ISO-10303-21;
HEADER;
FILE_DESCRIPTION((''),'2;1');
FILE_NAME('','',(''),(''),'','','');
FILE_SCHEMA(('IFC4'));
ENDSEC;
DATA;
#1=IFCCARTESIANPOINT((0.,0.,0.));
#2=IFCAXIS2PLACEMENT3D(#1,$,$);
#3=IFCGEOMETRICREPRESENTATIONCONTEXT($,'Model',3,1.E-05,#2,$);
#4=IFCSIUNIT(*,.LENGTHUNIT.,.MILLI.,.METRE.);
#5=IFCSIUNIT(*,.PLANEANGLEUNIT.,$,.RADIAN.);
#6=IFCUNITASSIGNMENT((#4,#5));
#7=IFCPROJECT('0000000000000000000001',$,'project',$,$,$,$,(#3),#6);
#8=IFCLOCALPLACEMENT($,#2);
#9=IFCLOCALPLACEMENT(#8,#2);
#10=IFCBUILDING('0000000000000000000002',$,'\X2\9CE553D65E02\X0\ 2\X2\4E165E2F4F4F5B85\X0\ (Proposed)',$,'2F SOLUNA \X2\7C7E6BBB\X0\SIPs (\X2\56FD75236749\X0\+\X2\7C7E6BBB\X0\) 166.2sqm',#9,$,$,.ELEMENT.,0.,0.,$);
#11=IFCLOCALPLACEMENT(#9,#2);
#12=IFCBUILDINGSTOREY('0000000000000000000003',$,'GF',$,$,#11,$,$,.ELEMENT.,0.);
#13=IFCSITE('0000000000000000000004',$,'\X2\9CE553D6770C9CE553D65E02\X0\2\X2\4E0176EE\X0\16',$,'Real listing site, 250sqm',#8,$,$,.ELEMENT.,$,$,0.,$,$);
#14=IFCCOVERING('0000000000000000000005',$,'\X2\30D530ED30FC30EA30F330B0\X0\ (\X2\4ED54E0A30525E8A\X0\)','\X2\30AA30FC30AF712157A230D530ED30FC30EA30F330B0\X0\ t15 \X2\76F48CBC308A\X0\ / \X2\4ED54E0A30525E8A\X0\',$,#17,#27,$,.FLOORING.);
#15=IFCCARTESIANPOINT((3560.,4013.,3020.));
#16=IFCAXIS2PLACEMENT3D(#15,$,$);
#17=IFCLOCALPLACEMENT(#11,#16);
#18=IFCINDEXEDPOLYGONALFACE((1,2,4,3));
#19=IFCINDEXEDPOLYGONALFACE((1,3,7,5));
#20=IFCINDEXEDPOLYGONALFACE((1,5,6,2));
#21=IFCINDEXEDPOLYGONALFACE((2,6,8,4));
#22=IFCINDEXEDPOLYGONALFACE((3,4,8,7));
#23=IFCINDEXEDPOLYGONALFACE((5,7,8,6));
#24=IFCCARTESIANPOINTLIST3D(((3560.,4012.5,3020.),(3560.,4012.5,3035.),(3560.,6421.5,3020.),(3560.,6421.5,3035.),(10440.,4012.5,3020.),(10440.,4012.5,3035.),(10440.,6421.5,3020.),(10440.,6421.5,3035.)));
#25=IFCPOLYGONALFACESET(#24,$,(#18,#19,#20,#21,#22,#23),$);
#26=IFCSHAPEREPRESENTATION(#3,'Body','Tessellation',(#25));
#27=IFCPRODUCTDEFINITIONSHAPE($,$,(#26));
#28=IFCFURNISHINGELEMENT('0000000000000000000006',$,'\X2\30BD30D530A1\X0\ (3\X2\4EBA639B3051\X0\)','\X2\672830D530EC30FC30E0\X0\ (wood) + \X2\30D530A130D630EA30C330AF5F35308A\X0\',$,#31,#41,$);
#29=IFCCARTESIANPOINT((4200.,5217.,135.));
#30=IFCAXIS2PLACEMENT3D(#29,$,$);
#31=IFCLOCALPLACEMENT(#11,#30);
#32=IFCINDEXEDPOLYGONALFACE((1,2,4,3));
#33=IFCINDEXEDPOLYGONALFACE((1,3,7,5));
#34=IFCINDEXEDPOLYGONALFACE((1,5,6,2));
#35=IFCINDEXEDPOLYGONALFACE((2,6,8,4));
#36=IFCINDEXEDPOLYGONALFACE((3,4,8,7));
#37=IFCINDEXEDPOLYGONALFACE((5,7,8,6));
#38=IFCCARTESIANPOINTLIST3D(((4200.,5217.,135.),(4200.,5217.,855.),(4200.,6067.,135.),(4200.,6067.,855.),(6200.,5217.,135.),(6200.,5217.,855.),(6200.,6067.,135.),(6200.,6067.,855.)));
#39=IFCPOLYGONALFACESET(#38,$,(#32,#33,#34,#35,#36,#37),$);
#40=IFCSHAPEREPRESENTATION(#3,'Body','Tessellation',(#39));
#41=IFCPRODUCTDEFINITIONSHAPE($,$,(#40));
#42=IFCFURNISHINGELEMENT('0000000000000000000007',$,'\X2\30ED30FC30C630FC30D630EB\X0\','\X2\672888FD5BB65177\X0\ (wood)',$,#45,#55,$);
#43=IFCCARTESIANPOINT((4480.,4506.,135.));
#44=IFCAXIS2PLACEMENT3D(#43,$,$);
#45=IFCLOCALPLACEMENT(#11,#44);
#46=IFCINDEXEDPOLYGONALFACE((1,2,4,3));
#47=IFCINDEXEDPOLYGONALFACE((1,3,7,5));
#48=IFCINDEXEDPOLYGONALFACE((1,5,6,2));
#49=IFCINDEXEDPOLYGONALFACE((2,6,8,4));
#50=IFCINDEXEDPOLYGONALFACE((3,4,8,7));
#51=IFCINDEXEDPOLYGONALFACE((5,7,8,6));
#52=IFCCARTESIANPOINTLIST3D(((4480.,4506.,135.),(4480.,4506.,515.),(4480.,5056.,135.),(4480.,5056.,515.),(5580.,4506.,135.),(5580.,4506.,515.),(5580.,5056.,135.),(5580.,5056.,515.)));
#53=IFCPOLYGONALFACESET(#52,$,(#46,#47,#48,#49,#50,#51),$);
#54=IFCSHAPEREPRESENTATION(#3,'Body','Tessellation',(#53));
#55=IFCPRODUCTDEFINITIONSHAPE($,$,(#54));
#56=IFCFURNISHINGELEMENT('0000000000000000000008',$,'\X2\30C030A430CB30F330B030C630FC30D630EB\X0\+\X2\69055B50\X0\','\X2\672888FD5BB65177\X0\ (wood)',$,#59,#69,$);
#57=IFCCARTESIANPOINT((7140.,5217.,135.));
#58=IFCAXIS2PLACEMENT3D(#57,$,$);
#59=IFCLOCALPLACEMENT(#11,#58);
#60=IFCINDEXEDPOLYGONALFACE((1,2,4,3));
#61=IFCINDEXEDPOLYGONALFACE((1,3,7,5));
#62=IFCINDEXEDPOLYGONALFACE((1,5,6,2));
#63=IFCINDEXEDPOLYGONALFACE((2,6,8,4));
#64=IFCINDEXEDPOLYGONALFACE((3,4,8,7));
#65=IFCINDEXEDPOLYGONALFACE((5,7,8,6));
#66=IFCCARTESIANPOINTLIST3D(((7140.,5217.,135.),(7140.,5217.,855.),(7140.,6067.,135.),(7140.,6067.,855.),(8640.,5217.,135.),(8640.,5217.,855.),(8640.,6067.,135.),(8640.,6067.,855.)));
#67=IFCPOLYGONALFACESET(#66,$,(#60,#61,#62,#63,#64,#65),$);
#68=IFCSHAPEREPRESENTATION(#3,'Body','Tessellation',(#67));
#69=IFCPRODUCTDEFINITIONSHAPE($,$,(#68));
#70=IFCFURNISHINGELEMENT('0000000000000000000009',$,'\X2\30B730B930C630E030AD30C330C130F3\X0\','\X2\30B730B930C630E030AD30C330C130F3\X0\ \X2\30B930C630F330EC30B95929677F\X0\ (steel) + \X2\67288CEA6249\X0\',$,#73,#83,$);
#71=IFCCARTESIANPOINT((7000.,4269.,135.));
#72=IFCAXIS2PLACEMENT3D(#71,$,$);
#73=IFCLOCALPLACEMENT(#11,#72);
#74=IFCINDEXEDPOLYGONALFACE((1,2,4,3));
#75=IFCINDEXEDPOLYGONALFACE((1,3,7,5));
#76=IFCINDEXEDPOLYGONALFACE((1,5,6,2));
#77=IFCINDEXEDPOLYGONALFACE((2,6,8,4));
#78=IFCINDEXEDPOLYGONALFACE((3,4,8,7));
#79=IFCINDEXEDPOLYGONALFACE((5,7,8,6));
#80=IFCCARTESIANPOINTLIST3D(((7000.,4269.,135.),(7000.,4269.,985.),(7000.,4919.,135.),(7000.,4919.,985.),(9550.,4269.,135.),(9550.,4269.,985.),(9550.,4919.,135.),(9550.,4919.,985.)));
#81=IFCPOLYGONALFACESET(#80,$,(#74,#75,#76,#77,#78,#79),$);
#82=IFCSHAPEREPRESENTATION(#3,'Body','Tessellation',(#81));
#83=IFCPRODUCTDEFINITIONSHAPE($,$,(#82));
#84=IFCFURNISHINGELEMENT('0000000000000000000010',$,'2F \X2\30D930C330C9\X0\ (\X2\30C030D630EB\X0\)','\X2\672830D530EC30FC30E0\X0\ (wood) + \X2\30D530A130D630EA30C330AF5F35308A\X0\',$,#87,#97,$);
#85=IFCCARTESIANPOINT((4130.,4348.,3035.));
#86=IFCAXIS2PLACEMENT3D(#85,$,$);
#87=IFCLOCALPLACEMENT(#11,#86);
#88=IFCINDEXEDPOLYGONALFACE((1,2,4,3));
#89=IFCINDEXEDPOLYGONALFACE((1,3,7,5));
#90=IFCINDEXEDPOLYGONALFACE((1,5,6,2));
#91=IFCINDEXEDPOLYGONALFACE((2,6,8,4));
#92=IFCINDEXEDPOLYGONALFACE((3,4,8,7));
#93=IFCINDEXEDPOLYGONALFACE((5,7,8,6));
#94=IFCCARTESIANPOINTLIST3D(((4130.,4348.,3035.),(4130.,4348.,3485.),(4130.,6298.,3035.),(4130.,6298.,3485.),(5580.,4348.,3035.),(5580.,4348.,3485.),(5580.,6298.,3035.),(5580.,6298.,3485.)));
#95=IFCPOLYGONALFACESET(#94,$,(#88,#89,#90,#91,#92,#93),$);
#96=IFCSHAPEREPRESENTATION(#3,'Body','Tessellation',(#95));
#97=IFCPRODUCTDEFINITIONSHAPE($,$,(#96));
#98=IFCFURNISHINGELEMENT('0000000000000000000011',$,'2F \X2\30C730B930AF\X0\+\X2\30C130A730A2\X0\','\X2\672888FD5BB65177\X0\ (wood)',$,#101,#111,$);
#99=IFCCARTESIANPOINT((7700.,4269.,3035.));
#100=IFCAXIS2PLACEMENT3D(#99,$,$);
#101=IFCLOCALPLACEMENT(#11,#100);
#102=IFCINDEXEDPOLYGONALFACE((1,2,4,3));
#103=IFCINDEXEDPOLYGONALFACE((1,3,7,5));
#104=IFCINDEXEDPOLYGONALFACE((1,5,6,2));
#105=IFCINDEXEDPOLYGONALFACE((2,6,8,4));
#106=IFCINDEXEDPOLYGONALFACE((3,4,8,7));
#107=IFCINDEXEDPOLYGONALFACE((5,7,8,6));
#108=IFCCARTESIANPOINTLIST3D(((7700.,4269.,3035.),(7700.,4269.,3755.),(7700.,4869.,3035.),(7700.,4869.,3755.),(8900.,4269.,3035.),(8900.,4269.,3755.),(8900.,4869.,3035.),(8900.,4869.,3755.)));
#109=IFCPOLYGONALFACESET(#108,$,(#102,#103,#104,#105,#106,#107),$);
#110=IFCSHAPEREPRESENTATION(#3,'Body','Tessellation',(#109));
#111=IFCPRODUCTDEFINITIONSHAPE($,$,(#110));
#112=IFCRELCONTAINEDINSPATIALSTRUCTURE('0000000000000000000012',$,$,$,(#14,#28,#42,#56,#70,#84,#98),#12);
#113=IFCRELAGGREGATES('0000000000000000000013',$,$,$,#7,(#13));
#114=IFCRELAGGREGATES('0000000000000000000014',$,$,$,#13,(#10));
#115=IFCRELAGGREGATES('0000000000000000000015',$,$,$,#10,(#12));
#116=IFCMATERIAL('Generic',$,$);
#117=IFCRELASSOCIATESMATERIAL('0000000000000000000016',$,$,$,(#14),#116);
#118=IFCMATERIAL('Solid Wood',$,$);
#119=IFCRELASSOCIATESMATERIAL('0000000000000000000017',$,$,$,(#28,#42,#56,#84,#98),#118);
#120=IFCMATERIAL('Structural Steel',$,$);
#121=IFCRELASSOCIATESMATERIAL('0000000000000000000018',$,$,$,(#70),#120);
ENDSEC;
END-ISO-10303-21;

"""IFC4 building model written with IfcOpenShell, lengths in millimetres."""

from ifc_helpers import new_model, si_unit, frame, frame_2d, origin, place, context, project, spatial, rectangle, extrude, material, element, save


model = new_model("IFC4")

# Units and contexts
model_context = context("Model", 3, precision=1e-05, world=origin())
ifc_project = project(units=[si_unit("LENGTHUNIT", "METRE", prefix="MILLI"), si_unit("PLANEANGLEUNIT", "RADIAN")], contexts=[model_context])

# Site, building, storey
site_placement = place(None, origin())
site = spatial("IfcSite", under=ifc_project, at=site_placement, Name="鳥取県鳥取市2丁目16", ObjectType="Real listing site, 250sqm", CompositionType="ELEMENT", RefElevation=0.0)
building_placement = place(site_placement, origin())
building = spatial("IfcBuilding", under=site, at=building_placement, Name="鳥取市 2世帯住宅 (Proposed)", ObjectType="2F SOLUNA 籾殻SIPs (国産杉+籾殻) 166.2sqm", CompositionType="ELEMENT", ElevationOfRefHeight=0.0, ElevationOfTerrain=0.0)
storey_placement = place(building_placement, origin())
storey = spatial("IfcBuildingStorey", under=building, at=storey_placement, Name="GF", CompositionType="ELEMENT", Elevation=0.0)

# Shared definitions
ifc_material_1 = material(Name="Solid Wood")

# Shared definitions
ifc_material_2 = material(Name="Generic")

# Shared definitions
ifc_material_3 = material(Name="Structural Steel")

# Covering
covering_placement = place(storey_placement, frame((3560.0, 4013.0, 3020.0)))
element("IfcCovering", 1, at=covering_placement, inside=storey, material=ifc_material_2, Name="フローリング (仕上げ床)", Description="オーク無垢フローリング t15 直貼り / 仕上げ床", PredefinedType="FLOORING", context=model_context, shape_type="SweptSolid", body=[
    extrude(rectangle(XDim=6880.0, YDim=2409.0, at=frame_2d((3440.0, 1204.0))), frame((3560.0, 4013.0, 3020.0)), (0.0, 0.0, 1.0), 15.0),
])

# Furnishing elements
furnishing_1_placement = place(storey_placement, frame((4200.0, 5217.0, 135.0)))
element("IfcFurnishingElement", 2, at=furnishing_1_placement, inside=storey, material=ifc_material_1, Name="ソファ (3人掛け)", Description="木フレーム (wood) + ファブリック張り", context=model_context, shape_type="SweptSolid", body=[
    extrude(rectangle(XDim=2000.0, YDim=850.0, at=frame_2d((1000.0, 425.0))), frame((4200.0, 5217.0, 135.0)), (0.0, 0.0, 1.0), 720.0),
])
furnishing_2_placement = place(storey_placement, frame((4480.0, 4506.0, 135.0)))
element("IfcFurnishingElement", 3, at=furnishing_2_placement, inside=storey, material=ifc_material_1, Name="ローテーブル", Description="木製家具 (wood)", context=model_context, shape_type="SweptSolid", body=[
    extrude(rectangle(XDim=1100.0, YDim=550.0, at=frame_2d((550.0, 275.0))), frame((4480.0, 4506.0, 135.0)), (0.0, 0.0, 1.0), 380.0),
])
furnishing_3_placement = place(storey_placement, frame((7140.0, 5217.0, 135.0)))
element("IfcFurnishingElement", 4, at=furnishing_3_placement, inside=storey, material=ifc_material_1, Name="ダイニングテーブル+椅子", Description="木製家具 (wood)", context=model_context, shape_type="SweptSolid", body=[
    extrude(rectangle(XDim=1500.0, YDim=850.0, at=frame_2d((750.0, 425.0))), frame((7140.0, 5217.0, 135.0)), (0.0, 0.0, 1.0), 720.0),
])
furnishing_4_placement = place(storey_placement, frame((7000.0, 4269.0, 135.0)))
element("IfcFurnishingElement", 5, at=furnishing_4_placement, inside=storey, material=ifc_material_3, Name="システムキッチン", Description="システムキッチン ステンレス天板 (steel) + 木質扉", context=model_context, shape_type="SweptSolid", body=[
    extrude(rectangle(XDim=2550.0, YDim=650.0, at=frame_2d((1275.0, 325.0))), frame((7000.0, 4269.0, 135.0)), (0.0, 0.0, 1.0), 850.0),
])
furnishing_5_placement = place(storey_placement, frame((4130.0, 4348.0, 3035.0)))
element("IfcFurnishingElement", 6, at=furnishing_5_placement, inside=storey, material=ifc_material_1, Name="2F ベッド (ダブル)", Description="木フレーム (wood) + ファブリック張り", context=model_context, shape_type="SweptSolid", body=[
    extrude(rectangle(XDim=1450.0, YDim=1950.0, at=frame_2d((725.0, 975.0))), frame((4130.0, 4348.0, 3035.0)), (0.0, 0.0, 1.0), 450.0),
])
furnishing_6_placement = place(storey_placement, frame((7700.0, 4269.0, 3035.0)))
element("IfcFurnishingElement", 7, at=furnishing_6_placement, inside=storey, material=ifc_material_1, Name="2F デスク+チェア", Description="木製家具 (wood)", context=model_context, shape_type="SweptSolid", body=[
    extrude(rectangle(XDim=1200.0, YDim=600.0, at=frame_2d((600.0, 300.0))), frame((7700.0, 4269.0, 3035.0)), (0.0, 0.0, 1.0), 720.0),
])

save(model, "model.ifc")
